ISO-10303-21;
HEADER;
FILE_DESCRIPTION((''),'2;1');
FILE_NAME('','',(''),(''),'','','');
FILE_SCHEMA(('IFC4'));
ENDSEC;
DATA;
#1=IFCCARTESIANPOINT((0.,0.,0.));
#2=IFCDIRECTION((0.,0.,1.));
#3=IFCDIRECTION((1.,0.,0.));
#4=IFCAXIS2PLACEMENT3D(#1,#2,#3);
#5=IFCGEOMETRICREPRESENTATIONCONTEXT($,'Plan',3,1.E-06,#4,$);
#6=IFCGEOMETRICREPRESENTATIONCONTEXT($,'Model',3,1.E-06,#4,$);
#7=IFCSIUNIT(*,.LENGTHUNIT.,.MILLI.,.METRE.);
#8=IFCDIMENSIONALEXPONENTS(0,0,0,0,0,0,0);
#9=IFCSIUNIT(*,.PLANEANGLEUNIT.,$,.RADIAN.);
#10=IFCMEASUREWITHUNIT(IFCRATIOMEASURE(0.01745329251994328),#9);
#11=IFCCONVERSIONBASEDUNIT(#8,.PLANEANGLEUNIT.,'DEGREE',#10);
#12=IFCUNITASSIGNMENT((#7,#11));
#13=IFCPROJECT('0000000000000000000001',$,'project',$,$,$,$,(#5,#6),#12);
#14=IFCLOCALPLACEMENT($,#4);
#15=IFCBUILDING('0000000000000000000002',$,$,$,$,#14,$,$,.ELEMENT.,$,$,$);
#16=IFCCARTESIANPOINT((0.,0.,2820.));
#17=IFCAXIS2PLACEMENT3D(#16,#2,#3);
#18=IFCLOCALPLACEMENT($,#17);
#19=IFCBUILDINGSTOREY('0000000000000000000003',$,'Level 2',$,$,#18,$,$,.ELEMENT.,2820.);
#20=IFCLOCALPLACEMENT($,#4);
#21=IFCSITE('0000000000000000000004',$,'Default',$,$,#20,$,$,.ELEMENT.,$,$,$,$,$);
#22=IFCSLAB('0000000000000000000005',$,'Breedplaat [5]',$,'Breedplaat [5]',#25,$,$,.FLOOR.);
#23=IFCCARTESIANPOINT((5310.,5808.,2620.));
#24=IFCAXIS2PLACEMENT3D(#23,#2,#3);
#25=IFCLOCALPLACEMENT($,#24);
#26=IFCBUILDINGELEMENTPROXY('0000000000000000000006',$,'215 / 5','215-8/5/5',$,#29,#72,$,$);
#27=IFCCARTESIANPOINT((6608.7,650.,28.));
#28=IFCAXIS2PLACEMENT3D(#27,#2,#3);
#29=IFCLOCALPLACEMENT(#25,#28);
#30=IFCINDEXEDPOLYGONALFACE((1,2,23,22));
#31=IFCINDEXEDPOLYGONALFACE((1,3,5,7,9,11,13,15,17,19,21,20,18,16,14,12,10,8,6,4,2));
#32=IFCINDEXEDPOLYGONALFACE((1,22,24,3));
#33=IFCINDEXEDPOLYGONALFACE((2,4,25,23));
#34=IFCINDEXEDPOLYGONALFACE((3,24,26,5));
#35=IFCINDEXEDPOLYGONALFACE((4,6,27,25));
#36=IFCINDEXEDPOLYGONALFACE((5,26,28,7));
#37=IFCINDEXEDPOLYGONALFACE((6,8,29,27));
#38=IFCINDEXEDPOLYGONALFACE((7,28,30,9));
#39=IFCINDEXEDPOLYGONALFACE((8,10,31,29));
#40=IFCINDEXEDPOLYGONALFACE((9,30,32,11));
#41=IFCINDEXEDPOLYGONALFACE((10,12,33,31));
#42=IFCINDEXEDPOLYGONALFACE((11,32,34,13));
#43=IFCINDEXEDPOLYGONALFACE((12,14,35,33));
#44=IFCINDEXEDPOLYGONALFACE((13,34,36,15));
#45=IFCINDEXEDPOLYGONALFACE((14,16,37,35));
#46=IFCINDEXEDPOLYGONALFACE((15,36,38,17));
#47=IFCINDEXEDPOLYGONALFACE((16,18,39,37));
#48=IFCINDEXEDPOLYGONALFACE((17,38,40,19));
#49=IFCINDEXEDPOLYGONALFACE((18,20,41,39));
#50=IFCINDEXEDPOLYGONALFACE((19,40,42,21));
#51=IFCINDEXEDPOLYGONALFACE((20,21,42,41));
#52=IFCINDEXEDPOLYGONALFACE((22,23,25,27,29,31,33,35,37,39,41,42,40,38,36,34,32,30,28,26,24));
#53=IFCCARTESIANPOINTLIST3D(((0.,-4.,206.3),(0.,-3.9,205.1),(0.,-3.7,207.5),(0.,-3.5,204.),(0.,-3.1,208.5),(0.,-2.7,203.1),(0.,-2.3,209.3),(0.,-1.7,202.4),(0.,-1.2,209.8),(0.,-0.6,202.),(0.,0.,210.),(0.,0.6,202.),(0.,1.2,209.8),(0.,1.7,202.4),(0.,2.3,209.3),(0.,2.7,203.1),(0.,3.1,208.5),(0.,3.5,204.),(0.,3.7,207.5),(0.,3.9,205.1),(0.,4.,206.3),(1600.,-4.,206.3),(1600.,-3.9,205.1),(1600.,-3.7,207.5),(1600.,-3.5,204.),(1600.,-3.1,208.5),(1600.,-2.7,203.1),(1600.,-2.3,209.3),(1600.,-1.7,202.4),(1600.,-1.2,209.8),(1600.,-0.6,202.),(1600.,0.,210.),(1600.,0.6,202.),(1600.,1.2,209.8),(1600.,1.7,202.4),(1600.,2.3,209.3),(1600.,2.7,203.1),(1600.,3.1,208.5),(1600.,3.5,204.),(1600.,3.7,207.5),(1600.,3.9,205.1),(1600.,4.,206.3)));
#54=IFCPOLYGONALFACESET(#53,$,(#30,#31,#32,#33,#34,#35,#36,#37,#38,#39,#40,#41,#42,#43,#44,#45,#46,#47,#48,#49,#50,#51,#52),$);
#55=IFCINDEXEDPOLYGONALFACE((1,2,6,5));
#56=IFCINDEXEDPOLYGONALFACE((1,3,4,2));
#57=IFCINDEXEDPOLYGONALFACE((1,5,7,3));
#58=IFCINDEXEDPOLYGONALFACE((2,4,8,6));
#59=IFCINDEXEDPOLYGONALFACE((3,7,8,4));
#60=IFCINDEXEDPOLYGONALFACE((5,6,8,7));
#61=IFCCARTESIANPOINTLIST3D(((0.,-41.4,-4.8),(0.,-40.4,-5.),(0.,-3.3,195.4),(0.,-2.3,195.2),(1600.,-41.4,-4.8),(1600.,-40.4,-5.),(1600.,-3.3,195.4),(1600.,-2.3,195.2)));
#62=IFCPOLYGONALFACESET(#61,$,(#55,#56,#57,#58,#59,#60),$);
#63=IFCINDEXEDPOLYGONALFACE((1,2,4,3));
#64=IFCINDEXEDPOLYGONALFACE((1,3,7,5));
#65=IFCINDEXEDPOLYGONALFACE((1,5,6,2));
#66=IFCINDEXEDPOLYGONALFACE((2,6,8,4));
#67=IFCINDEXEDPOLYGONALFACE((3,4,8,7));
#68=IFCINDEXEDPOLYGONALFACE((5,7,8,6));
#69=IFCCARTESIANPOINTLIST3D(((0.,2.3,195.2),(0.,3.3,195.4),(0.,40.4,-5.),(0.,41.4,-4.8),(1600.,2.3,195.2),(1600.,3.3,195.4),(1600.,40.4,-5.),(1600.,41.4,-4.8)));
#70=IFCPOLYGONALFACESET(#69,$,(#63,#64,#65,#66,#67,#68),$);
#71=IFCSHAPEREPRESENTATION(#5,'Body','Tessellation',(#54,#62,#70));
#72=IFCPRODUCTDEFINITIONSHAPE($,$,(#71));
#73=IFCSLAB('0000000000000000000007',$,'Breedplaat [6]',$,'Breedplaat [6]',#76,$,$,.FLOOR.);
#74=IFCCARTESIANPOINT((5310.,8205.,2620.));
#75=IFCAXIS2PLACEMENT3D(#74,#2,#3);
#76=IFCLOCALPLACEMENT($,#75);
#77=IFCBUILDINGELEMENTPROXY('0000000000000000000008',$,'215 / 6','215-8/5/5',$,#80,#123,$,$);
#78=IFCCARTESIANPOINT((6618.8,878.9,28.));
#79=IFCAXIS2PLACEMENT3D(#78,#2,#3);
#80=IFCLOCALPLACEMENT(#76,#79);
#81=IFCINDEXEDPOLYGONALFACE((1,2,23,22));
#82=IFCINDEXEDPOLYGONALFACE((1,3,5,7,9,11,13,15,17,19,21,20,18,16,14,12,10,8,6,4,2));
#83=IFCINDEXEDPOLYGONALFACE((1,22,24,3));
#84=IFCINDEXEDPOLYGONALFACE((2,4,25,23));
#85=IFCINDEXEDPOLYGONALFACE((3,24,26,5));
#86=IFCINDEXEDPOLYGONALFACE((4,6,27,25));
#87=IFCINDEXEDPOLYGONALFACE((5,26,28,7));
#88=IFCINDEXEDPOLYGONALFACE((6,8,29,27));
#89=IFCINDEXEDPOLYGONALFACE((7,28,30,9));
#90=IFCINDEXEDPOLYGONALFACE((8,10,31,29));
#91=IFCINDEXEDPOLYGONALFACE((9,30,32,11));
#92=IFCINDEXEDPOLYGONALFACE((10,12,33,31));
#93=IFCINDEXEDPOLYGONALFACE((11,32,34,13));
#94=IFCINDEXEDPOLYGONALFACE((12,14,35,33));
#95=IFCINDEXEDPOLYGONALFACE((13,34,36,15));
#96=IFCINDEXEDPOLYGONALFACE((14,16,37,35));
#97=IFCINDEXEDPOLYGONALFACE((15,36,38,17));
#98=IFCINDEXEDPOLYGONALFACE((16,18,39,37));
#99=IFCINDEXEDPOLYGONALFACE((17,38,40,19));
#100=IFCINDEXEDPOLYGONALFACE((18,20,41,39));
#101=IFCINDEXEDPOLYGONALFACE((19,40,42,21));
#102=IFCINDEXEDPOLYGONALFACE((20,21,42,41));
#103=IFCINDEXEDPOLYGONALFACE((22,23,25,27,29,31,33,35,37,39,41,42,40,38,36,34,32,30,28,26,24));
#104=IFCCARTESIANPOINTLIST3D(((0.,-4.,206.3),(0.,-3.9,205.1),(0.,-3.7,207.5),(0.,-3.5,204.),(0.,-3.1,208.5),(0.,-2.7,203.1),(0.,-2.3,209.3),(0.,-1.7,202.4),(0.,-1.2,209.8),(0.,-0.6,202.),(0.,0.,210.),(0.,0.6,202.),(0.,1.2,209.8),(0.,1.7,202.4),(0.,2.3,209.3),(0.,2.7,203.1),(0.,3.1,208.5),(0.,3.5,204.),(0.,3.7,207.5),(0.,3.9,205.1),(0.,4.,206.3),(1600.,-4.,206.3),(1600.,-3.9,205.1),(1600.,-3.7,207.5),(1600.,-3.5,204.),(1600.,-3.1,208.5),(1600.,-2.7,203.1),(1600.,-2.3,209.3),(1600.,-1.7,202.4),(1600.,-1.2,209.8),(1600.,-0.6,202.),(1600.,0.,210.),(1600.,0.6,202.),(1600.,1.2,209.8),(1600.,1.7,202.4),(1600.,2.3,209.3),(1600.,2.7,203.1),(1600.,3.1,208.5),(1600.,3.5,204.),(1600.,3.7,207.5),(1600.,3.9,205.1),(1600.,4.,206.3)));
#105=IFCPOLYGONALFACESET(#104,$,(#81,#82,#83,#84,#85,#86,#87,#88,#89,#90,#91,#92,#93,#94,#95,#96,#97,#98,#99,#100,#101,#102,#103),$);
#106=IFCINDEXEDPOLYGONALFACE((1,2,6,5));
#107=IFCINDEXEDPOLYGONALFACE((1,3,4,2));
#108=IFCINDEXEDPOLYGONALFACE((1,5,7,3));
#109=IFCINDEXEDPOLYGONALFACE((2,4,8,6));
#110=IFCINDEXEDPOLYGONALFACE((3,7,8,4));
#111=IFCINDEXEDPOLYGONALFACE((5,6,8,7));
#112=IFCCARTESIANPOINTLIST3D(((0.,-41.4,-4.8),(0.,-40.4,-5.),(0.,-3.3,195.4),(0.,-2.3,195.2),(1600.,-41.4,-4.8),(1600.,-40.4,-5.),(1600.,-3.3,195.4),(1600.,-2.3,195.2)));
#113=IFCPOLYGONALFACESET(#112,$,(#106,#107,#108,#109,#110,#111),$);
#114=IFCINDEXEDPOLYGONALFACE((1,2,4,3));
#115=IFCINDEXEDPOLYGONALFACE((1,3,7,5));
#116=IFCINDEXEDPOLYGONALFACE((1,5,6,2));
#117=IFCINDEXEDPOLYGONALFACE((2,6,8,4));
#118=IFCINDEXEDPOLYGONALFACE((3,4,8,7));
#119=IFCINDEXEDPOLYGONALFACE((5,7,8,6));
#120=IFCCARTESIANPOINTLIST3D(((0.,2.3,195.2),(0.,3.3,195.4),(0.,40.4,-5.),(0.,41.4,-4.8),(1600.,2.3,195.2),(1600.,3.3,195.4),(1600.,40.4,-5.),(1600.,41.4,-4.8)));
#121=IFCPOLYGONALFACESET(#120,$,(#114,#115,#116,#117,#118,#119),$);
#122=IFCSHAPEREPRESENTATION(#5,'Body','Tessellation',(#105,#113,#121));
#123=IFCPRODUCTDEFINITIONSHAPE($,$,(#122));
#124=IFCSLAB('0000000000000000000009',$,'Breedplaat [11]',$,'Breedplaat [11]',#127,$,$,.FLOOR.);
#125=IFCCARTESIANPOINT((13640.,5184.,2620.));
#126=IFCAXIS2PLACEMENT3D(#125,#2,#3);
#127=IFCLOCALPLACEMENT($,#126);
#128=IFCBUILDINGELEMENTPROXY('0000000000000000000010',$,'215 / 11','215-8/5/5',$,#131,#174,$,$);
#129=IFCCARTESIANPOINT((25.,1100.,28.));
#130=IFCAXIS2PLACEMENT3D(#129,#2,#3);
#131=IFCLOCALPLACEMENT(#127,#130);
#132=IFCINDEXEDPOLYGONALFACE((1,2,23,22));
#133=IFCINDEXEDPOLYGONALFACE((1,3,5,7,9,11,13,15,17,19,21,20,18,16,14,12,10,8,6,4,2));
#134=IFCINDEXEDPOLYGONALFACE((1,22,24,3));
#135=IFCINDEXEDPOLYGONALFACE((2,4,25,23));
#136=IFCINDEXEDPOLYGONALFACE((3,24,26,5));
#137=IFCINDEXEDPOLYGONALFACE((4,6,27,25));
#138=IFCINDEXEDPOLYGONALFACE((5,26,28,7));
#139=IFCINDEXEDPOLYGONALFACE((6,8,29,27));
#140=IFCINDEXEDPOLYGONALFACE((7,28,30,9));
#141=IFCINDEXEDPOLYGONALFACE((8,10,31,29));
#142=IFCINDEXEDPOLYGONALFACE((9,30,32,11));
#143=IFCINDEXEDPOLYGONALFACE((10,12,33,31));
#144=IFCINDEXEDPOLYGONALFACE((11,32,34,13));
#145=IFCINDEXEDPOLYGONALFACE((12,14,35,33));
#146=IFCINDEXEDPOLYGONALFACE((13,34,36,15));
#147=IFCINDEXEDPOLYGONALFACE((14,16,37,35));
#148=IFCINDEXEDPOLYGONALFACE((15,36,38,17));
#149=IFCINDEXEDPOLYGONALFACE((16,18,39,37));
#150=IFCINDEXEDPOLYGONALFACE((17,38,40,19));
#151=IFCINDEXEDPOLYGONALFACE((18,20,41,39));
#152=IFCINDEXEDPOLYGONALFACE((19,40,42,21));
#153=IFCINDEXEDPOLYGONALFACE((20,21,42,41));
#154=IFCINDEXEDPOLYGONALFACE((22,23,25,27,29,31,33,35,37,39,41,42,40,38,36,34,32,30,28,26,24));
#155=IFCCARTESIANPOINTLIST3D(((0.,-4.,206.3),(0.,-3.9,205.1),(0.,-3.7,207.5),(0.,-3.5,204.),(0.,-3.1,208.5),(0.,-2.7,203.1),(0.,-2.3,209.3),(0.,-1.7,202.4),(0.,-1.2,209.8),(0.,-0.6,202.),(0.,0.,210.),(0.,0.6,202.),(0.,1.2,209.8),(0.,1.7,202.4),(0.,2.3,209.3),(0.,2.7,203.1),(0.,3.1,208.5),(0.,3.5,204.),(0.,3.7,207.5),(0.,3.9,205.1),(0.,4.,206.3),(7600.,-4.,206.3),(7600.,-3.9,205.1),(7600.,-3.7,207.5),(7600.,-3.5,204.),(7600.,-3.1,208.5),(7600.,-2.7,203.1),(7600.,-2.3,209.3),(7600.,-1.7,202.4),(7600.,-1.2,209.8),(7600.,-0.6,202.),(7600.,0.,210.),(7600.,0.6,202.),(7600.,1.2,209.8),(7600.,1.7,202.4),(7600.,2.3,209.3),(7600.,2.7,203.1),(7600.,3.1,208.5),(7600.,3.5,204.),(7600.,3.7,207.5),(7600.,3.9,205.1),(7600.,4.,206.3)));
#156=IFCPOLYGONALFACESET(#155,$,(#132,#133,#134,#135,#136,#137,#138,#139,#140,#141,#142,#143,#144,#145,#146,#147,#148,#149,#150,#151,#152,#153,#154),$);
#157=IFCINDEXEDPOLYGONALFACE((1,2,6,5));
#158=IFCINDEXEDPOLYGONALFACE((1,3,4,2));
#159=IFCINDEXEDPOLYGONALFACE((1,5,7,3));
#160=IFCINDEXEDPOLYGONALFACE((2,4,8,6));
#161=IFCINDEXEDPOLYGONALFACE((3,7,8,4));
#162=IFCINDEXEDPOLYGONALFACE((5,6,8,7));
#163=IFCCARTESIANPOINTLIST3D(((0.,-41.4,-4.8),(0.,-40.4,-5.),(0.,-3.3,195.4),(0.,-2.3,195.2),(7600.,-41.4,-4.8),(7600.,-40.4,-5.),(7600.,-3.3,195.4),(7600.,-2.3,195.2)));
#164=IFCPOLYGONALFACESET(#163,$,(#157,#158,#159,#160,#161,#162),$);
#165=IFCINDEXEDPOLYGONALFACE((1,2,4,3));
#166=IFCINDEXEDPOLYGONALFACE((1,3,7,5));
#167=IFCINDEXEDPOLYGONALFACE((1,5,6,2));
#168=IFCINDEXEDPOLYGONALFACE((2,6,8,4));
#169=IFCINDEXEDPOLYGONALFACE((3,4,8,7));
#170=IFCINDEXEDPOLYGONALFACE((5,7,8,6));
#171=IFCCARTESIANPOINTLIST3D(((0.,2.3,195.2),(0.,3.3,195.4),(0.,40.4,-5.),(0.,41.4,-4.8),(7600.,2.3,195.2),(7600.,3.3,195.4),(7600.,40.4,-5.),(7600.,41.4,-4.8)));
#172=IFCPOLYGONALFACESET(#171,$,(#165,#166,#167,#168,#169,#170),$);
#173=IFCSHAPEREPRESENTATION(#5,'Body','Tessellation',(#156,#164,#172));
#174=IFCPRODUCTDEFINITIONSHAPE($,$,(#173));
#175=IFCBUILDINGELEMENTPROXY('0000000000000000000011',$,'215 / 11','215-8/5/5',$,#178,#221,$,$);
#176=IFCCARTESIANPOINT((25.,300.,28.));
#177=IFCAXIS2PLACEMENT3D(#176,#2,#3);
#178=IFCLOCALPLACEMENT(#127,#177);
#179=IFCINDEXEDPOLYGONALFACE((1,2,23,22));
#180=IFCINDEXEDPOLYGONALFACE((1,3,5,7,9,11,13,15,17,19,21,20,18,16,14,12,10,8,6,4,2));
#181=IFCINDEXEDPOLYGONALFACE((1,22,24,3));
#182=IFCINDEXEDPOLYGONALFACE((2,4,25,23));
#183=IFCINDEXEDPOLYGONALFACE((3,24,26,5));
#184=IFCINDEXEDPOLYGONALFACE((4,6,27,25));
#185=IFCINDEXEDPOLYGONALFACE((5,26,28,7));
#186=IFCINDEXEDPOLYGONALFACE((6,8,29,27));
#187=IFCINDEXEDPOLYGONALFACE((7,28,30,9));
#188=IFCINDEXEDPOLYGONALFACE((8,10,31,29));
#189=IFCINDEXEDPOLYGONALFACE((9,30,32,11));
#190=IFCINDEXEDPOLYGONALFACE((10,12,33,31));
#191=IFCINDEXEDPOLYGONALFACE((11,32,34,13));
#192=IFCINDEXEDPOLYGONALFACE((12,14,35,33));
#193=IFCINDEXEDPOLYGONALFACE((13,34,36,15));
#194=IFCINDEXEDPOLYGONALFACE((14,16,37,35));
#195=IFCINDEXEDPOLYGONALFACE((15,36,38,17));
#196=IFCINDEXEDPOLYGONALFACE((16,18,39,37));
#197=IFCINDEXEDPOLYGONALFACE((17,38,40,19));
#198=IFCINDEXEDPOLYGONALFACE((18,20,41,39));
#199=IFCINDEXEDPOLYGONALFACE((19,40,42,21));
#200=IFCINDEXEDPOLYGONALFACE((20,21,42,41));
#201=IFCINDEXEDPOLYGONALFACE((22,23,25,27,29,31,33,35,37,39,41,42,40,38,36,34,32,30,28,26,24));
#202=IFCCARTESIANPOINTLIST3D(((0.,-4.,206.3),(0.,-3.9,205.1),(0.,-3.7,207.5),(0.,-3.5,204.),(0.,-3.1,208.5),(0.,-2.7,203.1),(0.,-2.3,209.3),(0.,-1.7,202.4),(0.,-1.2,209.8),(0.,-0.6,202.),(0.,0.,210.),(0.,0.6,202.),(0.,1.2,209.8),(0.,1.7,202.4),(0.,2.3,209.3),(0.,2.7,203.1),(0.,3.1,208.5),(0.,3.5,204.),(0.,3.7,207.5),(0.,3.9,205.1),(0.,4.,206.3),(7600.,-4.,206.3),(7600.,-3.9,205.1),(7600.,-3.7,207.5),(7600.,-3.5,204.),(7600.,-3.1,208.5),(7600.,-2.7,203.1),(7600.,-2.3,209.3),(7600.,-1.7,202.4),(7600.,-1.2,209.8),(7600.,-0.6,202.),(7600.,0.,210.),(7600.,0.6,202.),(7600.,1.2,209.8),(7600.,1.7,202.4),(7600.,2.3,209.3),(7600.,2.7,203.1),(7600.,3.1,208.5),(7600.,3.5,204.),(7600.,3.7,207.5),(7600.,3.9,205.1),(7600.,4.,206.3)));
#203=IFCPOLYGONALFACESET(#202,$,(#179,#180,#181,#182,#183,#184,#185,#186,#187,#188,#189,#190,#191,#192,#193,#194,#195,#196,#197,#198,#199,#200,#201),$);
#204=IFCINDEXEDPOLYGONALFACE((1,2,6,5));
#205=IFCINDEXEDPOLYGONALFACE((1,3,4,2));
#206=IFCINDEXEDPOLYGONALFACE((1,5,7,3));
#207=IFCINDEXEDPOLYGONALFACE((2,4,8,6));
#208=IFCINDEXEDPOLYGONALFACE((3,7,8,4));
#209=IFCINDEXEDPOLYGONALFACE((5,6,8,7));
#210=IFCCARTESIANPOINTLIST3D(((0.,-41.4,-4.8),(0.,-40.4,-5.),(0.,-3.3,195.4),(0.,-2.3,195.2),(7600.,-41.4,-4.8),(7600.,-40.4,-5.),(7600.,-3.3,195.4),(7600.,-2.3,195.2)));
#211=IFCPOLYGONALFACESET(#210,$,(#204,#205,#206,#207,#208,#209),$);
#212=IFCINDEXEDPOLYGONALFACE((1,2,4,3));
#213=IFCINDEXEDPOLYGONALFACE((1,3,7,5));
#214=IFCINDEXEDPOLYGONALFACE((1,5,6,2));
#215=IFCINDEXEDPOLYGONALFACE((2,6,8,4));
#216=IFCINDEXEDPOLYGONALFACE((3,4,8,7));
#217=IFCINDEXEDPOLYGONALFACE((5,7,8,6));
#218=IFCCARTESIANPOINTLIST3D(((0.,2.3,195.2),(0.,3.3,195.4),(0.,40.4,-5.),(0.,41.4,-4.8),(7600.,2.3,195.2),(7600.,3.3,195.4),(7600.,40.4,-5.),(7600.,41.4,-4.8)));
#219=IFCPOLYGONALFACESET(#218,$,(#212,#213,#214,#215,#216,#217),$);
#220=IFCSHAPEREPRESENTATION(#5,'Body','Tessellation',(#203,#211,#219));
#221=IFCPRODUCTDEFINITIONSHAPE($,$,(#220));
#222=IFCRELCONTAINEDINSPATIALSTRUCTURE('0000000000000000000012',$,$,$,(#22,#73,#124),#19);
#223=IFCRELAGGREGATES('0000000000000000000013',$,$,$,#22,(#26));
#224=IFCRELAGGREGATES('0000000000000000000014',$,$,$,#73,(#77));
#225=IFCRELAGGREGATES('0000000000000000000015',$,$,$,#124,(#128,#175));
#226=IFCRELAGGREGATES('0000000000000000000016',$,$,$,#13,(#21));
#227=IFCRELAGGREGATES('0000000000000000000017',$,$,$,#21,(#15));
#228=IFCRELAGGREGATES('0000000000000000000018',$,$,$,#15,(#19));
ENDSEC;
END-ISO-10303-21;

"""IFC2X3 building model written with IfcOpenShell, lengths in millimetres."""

from ifc_helpers import new_model, entity, si_unit, converted_unit, frame, origin_with_axes, origin_2d_with_axis, place, context, project, spatial, rectangle, circle, extrude, element, aggregate, save


model = new_model("IFC2X3")

# Units and contexts
plan_context = context("Plan", 3, precision=1e-06, world=origin_with_axes())
model_context = context("Model", 3, precision=1e-06, world=origin_with_axes())
ifc_project = project(units=[si_unit("LENGTHUNIT", "METRE", prefix="MILLI"), converted_unit("PLANEANGLEUNIT", "DEGREE", entity("IfcRatioMeasure", 0.01745329251994328), si_unit("PLANEANGLEUNIT", "RADIAN"), dimensions=[0, 0, 0, 0, 0, 0, 0])], contexts=[plan_context, model_context])

# Site, building, storey
site_placement = place(None, origin_with_axes())
site = spatial("IfcSite", under=ifc_project, at=site_placement, Name="Default", CompositionType="ELEMENT")
building_placement = place(None, origin_with_axes())
building = spatial("IfcBuilding", under=site, at=building_placement, CompositionType="ELEMENT")
storey_placement = place(None, frame((0.0, 0.0, 2820.0), z_axis=(0.0, 0.0, 1.0), x_axis=(1.0, 0.0, 0.0)))
storey = spatial("IfcBuildingStorey", under=building, at=storey_placement, Name="Level 2", CompositionType="ELEMENT", Elevation=2820.0)

# Slabs, building element proxies
slab_1_placement = place(None, frame((5310.0, 5808.0, 2620.0), z_axis=(0.0, 0.0, 1.0), x_axis=(1.0, 0.0, 0.0)))
slab_1 = element("IfcSlab", 1, at=slab_1_placement, inside=storey, Name="Breedplaat [5]", ObjectType="Breedplaat [5]", PredefinedType="FLOOR")
proxy_1_placement = place(slab_1_placement, frame((6608.7, 650.0, 28.0), z_axis=(0.0, 0.0, 1.0), x_axis=(1.0, 0.0, 0.0)))
proxy_1 = element("IfcBuildingElementProxy", 2, at=proxy_1_placement, Name="215 / 5", Description="215-8/5/5", context=plan_context, shape_type="SweptSolid", body=[
    extrude(circle(Radius=4.0, at=origin_2d_with_axis()), frame((0.0, 0.0, 206.0), z_axis=(1.0, 0.0, 0.0), x_axis=(0.0, 0.0, 1.0)), (0.0, 0.0, 1.0), 1600.0),
    extrude(rectangle(XDim=203.8, YDim=1.0, at=origin_2d_with_axis()), frame((0.0, -21.9, 95.2), z_axis=(1.0, 0.0, 0.0), x_axis=(0.0, 0.187112, 0.982339)), (0.0, 0.0, 1.0), 1600.0),
    extrude(rectangle(XDim=203.8, YDim=1.0, at=origin_2d_with_axis()), frame((0.0, 21.9, 95.2), z_axis=(1.0, 0.0, 0.0), x_axis=(0.0, -0.187112, 0.982339)), (0.0, 0.0, 1.0), 1600.0),
])
aggregate(slab_1, [proxy_1])
slab_2_placement = place(None, frame((5310.0, 8205.0, 2620.0), z_axis=(0.0, 0.0, 1.0), x_axis=(1.0, 0.0, 0.0)))
slab_2 = element("IfcSlab", 3, at=slab_2_placement, inside=storey, Name="Breedplaat [6]", ObjectType="Breedplaat [6]", PredefinedType="FLOOR")
proxy_2_placement = place(slab_2_placement, frame((6618.8, 878.9, 28.0), z_axis=(0.0, 0.0, 1.0), x_axis=(1.0, 0.0, 0.0)))
proxy_2 = element("IfcBuildingElementProxy", 4, at=proxy_2_placement, Name="215 / 6", Description="215-8/5/5", context=plan_context, shape_type="SweptSolid", body=[
    extrude(circle(Radius=4.0, at=origin_2d_with_axis()), frame((0.0, 0.0, 206.0), z_axis=(1.0, 0.0, 0.0), x_axis=(0.0, 0.0, 1.0)), (0.0, 0.0, 1.0), 1600.0),
    extrude(rectangle(XDim=203.8, YDim=1.0, at=origin_2d_with_axis()), frame((0.0, -21.9, 95.2), z_axis=(1.0, 0.0, 0.0), x_axis=(0.0, 0.187112, 0.982339)), (0.0, 0.0, 1.0), 1600.0),
    extrude(rectangle(XDim=203.8, YDim=1.0, at=origin_2d_with_axis()), frame((0.0, 21.9, 95.2), z_axis=(1.0, 0.0, 0.0), x_axis=(0.0, -0.187112, 0.982339)), (0.0, 0.0, 1.0), 1600.0),
])
aggregate(slab_2, [proxy_2])
slab_3_placement = place(None, frame((13640.0, 5184.0, 2620.0), z_axis=(0.0, 0.0, 1.0), x_axis=(1.0, 0.0, 0.0)))
slab_3 = element("IfcSlab", 5, at=slab_3_placement, inside=storey, Name="Breedplaat [11]", ObjectType="Breedplaat [11]", PredefinedType="FLOOR")
proxy_3_placement = place(slab_3_placement, frame((25.0, 1100.0, 28.0), z_axis=(0.0, 0.0, 1.0), x_axis=(1.0, 0.0, 0.0)))
proxy_3 = element("IfcBuildingElementProxy", 6, at=proxy_3_placement, Name="215 / 11", Description="215-8/5/5", context=plan_context, shape_type="SweptSolid", body=[
    extrude(circle(Radius=4.0, at=origin_2d_with_axis()), frame((0.0, 0.0, 206.0), z_axis=(1.0, 0.0, 0.0), x_axis=(0.0, 0.0, 1.0)), (0.0, 0.0, 1.0), 7600.0),
    extrude(rectangle(XDim=203.8, YDim=1.0, at=origin_2d_with_axis()), frame((0.0, -21.9, 95.2), z_axis=(1.0, 0.0, 0.0), x_axis=(0.0, 0.187112, 0.982339)), (0.0, 0.0, 1.0), 7600.0),
    extrude(rectangle(XDim=203.8, YDim=1.0, at=origin_2d_with_axis()), frame((0.0, 21.9, 95.2), z_axis=(1.0, 0.0, 0.0), x_axis=(0.0, -0.187112, 0.982339)), (0.0, 0.0, 1.0), 7600.0),
])
proxy_4_placement = place(slab_3_placement, frame((25.0, 300.0, 28.0), z_axis=(0.0, 0.0, 1.0), x_axis=(1.0, 0.0, 0.0)))
proxy_4 = element("IfcBuildingElementProxy", 7, at=proxy_4_placement, Name="215 / 11", Description="215-8/5/5", context=plan_context, shape_type="SweptSolid", body=[
    extrude(circle(Radius=4.0, at=origin_2d_with_axis()), frame((0.0, 0.0, 206.0), z_axis=(1.0, 0.0, 0.0), x_axis=(0.0, 0.0, 1.0)), (0.0, 0.0, 1.0), 7600.0),
    extrude(rectangle(XDim=203.8, YDim=1.0, at=origin_2d_with_axis()), frame((0.0, -21.9, 95.2), z_axis=(1.0, 0.0, 0.0), x_axis=(0.0, 0.187112, 0.982339)), (0.0, 0.0, 1.0), 7600.0),
    extrude(rectangle(XDim=203.8, YDim=1.0, at=origin_2d_with_axis()), frame((0.0, 21.9, 95.2), z_axis=(1.0, 0.0, 0.0), x_axis=(0.0, -0.187112, 0.982339)), (0.0, 0.0, 1.0), 7600.0),
])
aggregate(slab_3, [proxy_3, proxy_4])

save(model, "model.ifc")
